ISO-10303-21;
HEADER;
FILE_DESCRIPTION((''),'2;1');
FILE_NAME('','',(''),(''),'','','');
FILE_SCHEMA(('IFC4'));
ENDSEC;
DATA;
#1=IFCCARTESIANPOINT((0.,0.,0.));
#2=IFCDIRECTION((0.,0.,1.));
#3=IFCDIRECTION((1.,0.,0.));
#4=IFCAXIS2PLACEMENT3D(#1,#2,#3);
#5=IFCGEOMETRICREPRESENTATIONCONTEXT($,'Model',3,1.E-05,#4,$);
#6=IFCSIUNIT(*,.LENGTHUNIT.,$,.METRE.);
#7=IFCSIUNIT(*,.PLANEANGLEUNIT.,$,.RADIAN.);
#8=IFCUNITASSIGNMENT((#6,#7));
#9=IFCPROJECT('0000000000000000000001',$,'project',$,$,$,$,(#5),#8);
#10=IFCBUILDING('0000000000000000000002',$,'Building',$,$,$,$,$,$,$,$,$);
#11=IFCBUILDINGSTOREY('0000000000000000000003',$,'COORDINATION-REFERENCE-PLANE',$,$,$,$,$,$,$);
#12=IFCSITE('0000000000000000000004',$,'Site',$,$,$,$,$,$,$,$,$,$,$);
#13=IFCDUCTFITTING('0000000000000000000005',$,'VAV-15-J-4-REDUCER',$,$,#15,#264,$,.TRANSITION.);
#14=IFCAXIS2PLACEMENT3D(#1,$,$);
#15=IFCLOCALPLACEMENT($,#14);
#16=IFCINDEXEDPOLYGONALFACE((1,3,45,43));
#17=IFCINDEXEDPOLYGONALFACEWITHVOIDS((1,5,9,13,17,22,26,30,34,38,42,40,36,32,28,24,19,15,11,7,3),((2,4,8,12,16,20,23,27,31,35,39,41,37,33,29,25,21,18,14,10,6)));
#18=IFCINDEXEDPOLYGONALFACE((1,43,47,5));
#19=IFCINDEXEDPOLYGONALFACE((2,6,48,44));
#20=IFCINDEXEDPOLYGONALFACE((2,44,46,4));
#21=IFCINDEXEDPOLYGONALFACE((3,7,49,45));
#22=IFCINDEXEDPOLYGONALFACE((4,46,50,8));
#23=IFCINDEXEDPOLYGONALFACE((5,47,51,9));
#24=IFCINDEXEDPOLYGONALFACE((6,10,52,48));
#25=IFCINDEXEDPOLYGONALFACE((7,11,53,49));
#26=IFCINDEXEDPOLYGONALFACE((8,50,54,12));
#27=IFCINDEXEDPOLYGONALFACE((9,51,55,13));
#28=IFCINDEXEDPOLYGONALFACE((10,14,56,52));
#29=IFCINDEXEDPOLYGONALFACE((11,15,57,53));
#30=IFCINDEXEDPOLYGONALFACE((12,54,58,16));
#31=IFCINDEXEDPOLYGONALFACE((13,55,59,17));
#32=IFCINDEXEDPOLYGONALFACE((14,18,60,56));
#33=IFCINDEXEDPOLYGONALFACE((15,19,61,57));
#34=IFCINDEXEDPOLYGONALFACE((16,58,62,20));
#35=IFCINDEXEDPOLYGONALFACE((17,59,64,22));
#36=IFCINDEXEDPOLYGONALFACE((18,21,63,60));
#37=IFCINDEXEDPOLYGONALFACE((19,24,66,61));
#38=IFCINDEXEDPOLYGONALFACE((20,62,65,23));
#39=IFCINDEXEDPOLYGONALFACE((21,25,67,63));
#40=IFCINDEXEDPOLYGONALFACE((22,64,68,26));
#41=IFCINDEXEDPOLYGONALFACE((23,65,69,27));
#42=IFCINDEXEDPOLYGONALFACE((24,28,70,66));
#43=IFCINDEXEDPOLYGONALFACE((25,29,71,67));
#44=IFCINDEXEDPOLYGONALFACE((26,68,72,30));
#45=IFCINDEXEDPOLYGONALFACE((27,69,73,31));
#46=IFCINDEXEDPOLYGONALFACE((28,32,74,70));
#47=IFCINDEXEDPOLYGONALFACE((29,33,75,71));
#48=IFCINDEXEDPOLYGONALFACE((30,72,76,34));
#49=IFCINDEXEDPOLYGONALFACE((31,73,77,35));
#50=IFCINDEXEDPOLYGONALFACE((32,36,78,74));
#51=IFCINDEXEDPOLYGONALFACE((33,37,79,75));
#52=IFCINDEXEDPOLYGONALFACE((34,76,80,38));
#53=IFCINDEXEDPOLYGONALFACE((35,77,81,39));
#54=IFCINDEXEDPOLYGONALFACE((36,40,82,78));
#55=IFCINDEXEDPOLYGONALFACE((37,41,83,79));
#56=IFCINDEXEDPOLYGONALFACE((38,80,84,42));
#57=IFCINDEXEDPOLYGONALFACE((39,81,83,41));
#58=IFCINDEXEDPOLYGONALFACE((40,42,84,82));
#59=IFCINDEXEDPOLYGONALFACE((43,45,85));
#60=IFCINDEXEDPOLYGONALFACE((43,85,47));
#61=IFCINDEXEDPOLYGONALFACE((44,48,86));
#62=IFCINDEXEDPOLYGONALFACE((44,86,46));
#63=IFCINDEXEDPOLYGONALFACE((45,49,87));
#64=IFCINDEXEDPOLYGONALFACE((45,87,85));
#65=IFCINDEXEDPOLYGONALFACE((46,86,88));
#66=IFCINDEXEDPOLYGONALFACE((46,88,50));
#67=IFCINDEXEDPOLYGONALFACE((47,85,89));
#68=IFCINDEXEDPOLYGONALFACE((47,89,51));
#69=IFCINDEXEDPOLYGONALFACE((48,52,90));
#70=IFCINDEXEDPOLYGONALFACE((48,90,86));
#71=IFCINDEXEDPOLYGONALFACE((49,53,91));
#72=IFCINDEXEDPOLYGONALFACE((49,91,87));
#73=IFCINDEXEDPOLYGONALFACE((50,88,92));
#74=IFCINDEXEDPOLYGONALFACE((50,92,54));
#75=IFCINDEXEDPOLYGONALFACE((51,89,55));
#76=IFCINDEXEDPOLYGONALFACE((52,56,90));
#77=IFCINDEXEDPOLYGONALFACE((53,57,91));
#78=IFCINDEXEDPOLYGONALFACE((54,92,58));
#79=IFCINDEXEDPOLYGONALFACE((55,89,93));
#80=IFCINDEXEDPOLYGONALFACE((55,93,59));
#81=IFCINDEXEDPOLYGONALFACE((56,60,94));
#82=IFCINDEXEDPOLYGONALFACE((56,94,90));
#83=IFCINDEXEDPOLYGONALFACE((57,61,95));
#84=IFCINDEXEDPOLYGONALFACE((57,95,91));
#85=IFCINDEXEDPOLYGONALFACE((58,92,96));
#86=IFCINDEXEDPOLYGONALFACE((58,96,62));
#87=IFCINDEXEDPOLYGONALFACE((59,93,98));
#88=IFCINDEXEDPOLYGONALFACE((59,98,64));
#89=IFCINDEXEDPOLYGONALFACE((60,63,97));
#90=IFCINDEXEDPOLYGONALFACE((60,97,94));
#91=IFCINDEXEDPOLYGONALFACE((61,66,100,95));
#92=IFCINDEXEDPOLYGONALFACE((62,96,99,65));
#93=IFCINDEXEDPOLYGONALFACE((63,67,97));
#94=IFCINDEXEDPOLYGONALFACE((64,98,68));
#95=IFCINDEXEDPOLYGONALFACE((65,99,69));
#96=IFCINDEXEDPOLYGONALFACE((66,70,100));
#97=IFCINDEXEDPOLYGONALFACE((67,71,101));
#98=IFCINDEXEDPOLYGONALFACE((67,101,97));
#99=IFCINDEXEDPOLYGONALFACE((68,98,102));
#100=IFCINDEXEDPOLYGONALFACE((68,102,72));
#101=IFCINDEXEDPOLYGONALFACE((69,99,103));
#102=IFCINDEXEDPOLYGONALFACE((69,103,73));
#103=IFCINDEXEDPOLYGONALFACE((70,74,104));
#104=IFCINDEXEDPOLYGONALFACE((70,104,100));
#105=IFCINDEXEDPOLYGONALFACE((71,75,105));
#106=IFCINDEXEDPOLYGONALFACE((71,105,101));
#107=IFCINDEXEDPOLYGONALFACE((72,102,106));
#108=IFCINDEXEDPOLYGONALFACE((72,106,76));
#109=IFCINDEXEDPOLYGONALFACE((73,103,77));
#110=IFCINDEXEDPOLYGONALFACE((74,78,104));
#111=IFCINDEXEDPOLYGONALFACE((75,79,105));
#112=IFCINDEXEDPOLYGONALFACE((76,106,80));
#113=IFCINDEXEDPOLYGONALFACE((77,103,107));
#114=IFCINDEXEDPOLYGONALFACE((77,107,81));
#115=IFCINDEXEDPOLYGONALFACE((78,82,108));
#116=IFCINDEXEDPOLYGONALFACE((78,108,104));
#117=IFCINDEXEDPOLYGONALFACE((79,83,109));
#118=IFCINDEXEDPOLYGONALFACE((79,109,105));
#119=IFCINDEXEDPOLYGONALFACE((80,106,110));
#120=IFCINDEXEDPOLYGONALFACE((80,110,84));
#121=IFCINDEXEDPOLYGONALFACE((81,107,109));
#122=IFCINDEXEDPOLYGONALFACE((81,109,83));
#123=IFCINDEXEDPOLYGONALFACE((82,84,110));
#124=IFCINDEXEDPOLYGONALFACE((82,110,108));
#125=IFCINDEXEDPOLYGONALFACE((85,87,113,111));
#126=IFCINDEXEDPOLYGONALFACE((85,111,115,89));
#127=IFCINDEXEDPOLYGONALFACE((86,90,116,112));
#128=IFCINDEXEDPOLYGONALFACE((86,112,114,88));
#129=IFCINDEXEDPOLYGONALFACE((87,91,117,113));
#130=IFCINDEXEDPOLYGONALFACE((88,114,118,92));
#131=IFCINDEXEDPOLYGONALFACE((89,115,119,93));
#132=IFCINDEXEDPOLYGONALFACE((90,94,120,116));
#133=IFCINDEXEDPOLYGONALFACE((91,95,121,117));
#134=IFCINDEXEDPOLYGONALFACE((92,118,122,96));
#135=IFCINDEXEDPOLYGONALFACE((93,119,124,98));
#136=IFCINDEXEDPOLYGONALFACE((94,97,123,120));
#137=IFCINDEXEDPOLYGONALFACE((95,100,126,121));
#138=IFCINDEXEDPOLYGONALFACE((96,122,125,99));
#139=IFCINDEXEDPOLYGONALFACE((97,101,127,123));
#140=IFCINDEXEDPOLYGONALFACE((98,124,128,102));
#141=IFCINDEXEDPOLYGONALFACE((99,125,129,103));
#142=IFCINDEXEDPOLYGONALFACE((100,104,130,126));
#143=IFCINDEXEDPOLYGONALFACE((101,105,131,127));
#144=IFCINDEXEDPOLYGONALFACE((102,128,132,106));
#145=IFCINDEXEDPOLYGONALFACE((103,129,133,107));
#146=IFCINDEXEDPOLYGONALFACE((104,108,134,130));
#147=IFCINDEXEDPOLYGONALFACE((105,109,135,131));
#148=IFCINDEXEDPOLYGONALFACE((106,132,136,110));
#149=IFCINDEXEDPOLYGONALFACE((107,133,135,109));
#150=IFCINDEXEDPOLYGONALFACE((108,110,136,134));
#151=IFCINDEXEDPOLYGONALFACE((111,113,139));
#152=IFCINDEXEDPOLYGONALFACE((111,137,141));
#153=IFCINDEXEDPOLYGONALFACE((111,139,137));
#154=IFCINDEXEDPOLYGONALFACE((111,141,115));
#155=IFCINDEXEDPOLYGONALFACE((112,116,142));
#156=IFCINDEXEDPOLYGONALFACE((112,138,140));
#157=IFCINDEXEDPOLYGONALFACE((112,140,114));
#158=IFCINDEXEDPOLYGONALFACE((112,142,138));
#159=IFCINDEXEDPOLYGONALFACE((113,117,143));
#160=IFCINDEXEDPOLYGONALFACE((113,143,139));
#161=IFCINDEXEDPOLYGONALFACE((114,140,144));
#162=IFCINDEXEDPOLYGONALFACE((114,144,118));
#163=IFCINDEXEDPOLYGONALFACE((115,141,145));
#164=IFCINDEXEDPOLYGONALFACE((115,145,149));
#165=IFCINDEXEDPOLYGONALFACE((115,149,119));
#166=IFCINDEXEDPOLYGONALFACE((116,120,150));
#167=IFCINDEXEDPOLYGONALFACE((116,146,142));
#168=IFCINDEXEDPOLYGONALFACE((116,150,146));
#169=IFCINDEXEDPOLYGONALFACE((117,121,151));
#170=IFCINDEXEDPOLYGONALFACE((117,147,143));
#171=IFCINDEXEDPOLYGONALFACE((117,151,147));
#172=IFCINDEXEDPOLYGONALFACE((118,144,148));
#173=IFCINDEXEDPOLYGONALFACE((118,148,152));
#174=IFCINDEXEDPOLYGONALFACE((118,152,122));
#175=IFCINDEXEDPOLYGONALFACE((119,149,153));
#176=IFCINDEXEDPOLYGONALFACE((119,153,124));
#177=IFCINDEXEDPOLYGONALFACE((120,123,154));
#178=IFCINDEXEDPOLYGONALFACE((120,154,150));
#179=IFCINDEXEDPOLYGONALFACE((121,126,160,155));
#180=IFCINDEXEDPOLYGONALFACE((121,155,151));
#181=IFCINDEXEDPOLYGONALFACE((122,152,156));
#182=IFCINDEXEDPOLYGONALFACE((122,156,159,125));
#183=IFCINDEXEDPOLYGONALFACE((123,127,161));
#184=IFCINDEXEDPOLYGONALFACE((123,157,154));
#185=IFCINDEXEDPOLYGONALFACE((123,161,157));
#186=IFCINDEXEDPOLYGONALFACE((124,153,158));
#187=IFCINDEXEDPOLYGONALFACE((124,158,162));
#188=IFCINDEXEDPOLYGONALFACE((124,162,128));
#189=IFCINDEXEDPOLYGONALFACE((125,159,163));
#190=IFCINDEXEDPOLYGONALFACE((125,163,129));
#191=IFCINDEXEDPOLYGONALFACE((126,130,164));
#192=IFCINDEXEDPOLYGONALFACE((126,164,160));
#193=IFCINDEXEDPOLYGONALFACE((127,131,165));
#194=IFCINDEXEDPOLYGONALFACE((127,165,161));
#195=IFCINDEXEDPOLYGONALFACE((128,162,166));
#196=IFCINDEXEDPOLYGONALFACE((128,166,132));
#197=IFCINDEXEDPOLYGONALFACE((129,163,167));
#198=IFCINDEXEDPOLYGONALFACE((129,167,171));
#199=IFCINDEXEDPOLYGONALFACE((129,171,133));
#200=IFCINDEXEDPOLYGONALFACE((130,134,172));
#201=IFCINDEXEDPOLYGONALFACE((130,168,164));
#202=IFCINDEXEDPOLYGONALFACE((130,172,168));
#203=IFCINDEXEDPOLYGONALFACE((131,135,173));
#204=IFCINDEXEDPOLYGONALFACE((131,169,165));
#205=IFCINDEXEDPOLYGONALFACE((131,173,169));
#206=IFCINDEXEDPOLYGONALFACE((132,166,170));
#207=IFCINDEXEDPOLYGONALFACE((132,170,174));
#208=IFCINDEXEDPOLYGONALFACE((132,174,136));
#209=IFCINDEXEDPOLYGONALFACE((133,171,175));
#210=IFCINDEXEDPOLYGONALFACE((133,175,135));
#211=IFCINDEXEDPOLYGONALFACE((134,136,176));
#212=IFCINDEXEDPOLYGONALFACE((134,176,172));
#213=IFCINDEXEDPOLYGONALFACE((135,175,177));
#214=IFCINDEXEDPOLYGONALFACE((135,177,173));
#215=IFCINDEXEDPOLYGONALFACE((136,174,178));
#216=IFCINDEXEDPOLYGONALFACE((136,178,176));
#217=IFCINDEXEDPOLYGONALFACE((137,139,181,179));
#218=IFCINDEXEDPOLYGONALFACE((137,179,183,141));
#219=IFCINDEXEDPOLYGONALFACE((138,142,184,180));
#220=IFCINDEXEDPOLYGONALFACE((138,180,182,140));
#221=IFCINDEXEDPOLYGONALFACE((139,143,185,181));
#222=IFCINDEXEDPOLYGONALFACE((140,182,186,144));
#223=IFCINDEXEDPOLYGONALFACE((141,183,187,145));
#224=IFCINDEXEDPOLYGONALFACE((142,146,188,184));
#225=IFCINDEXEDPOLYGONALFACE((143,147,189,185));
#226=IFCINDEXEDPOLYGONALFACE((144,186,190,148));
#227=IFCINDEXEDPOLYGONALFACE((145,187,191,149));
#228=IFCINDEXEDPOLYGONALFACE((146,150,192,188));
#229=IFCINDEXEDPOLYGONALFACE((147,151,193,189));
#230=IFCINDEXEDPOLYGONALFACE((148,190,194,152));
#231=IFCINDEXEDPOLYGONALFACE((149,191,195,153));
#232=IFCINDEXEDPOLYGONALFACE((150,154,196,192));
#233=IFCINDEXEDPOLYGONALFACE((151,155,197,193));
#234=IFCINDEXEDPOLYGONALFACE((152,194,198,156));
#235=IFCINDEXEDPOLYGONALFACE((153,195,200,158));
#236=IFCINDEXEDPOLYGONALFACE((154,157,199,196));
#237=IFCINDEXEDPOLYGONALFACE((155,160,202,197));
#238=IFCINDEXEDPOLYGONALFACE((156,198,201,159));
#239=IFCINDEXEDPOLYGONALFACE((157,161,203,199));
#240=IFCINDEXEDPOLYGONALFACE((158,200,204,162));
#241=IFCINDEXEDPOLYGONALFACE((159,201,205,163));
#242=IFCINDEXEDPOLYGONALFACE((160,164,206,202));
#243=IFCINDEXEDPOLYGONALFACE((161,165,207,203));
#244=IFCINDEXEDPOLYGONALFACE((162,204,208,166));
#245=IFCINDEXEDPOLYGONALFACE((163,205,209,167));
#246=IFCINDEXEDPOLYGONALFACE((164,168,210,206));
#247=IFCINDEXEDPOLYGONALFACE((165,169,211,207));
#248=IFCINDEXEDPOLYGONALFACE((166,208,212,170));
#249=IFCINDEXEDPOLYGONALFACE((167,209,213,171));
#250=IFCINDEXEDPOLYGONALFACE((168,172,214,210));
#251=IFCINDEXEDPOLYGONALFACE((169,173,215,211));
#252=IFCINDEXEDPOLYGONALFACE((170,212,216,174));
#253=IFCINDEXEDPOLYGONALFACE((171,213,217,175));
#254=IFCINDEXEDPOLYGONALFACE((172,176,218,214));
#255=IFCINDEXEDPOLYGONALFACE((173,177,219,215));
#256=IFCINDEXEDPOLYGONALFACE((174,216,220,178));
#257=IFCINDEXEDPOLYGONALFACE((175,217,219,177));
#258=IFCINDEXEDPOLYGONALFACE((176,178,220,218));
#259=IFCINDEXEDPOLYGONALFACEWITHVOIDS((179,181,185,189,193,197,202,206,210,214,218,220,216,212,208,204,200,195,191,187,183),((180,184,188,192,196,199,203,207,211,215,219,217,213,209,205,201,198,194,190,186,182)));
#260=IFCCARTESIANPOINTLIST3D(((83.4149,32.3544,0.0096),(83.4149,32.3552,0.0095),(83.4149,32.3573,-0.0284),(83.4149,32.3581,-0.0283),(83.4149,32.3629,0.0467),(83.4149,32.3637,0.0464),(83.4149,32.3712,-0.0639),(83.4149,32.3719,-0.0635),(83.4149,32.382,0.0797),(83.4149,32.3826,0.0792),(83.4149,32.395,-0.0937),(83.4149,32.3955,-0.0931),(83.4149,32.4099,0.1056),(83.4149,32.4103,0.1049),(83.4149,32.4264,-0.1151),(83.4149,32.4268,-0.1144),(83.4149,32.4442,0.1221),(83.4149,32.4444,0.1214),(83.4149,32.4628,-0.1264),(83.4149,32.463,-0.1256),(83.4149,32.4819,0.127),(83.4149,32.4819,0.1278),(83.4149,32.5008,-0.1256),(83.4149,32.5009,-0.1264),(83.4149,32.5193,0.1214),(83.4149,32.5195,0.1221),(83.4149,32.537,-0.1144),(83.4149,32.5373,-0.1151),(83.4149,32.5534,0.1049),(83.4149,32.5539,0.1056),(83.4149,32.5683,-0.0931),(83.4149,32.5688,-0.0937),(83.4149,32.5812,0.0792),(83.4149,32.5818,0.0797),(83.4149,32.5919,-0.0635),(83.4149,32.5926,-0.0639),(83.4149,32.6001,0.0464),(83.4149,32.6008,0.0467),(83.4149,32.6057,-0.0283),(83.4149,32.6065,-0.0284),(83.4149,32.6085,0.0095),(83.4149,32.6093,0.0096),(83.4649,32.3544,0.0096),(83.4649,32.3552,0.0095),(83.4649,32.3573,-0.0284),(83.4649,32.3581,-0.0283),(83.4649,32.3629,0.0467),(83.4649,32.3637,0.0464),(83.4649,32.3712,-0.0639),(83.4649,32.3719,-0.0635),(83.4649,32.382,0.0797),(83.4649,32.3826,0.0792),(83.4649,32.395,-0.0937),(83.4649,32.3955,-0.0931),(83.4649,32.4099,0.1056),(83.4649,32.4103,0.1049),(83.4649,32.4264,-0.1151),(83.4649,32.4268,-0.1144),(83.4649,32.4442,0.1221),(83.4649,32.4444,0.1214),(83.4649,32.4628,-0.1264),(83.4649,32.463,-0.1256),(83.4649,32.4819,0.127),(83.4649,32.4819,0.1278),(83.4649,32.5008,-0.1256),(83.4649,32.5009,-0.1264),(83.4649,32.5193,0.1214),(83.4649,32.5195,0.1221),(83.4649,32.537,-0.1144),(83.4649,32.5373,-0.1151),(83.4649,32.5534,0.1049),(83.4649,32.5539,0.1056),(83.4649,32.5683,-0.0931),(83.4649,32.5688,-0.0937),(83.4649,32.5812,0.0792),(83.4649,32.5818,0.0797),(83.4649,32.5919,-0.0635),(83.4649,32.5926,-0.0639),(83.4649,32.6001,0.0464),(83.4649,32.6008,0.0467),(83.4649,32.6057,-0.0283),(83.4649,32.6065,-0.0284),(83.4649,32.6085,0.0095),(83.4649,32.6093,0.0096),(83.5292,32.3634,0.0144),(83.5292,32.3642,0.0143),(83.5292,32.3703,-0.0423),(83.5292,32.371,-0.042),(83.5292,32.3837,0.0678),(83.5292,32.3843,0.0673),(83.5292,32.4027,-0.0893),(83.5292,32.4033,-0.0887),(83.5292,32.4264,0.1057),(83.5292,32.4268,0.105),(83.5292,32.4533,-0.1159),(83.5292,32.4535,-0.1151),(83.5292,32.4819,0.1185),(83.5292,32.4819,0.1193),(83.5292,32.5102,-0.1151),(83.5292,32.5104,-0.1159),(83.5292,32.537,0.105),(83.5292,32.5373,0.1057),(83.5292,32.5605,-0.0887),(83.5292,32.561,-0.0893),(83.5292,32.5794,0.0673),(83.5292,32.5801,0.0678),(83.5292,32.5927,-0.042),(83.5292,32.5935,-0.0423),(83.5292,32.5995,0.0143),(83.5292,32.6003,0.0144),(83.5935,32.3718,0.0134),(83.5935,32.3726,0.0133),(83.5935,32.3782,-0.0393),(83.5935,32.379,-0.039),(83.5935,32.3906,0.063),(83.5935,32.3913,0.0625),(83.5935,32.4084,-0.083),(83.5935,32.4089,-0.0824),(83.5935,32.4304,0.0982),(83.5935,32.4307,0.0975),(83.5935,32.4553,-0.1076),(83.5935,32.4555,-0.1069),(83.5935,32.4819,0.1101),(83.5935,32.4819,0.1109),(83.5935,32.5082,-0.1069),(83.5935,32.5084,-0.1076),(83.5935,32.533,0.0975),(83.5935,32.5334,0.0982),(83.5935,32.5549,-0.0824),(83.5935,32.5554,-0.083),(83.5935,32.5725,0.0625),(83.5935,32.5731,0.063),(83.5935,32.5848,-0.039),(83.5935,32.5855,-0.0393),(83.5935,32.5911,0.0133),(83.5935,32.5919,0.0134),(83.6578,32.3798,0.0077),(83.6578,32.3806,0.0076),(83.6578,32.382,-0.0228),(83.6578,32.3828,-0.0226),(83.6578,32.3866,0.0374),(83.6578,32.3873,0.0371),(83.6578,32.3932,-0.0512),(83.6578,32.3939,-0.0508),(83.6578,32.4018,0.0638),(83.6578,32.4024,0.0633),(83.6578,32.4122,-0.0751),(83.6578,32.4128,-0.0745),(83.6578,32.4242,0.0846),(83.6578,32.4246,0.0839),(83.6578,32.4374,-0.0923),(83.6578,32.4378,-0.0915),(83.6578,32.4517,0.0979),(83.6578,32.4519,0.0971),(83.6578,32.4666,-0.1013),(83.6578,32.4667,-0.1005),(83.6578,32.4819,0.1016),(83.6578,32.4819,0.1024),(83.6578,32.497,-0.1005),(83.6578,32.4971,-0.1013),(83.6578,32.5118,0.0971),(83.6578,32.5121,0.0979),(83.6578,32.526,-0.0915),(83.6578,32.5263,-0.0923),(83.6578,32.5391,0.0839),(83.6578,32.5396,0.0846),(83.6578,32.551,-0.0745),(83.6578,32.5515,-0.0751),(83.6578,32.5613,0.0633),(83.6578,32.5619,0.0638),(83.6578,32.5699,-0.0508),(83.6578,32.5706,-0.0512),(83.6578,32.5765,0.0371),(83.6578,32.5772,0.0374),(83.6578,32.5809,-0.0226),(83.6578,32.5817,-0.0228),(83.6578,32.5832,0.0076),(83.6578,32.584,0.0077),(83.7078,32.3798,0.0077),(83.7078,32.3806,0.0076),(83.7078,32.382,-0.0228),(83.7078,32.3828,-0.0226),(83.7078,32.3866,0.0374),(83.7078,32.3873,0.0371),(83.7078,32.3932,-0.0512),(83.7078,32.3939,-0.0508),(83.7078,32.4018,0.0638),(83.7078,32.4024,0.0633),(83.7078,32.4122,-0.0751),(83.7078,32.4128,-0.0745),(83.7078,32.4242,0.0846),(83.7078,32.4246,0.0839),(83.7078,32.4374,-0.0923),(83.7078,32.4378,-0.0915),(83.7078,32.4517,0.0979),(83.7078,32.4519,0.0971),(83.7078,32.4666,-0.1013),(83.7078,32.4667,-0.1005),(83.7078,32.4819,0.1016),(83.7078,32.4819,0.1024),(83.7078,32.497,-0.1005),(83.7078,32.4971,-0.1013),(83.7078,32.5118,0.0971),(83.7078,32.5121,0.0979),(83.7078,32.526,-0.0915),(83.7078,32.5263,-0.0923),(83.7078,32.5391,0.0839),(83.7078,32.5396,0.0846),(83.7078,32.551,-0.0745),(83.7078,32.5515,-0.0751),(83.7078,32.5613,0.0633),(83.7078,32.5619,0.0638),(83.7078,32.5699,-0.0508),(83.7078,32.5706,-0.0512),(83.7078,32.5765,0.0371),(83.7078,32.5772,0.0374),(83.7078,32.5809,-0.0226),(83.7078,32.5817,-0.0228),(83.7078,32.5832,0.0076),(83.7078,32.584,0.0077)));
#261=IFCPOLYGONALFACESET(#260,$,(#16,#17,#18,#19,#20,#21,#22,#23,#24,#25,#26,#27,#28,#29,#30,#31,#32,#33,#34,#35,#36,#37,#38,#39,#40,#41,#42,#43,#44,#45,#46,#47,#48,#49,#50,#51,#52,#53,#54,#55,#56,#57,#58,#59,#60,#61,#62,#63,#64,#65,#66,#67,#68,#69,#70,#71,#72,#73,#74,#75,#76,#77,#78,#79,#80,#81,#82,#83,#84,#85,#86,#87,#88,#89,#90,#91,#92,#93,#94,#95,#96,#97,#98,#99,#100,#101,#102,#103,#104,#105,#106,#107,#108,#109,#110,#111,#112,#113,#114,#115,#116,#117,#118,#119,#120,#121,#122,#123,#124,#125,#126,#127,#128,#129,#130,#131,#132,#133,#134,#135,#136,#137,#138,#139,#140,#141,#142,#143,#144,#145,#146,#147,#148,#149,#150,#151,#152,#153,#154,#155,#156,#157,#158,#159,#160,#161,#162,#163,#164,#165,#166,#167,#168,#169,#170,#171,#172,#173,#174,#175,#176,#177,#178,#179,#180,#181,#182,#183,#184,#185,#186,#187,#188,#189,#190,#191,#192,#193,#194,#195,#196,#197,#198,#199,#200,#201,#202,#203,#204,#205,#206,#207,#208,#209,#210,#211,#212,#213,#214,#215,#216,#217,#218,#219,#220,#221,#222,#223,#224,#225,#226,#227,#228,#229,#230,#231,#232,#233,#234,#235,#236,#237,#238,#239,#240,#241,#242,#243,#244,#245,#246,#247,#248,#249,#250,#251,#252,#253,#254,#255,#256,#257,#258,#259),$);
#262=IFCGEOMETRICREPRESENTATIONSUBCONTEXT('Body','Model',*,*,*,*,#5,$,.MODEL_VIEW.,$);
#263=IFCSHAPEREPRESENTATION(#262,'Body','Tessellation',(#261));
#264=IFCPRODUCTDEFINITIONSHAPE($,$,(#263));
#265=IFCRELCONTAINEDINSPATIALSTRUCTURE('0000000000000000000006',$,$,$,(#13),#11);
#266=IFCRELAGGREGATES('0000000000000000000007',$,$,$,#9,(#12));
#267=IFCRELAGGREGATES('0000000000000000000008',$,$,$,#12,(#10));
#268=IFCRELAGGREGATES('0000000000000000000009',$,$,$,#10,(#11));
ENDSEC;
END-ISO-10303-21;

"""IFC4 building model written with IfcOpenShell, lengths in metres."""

from ifc_helpers import new_model, entity, si_unit, frame, origin_with_axes, place, context, subcontext, project, spatial, element, save


model = new_model("IFC4")

# Units and contexts
model_context = context("Model", 3, precision=1e-05, world=origin_with_axes())
body_context_1 = subcontext(model_context, "Body", "Model", "MODEL_VIEW")
ifc_project = project(units=[si_unit("LENGTHUNIT", "METRE"), si_unit("PLANEANGLEUNIT", "RADIAN")], contexts=[model_context])

# Site, building, storey
site = spatial("IfcSite", under=ifc_project, Name="Site")
building = spatial("IfcBuilding", under=site, Name="Building")
storey = spatial("IfcBuildingStorey", under=building, Name="COORDINATION-REFERENCE-PLANE")

# Duct fitting
duct_fitting_1_placement = place(None, frame((83.4149, 32.4819, 0.0), z_axis=(0.0, 1.0, 0.0), x_axis=(0.0, 0.0, 1.0)))
element("IfcDuctFitting", 1, at=duct_fitting_1_placement, inside=storey, Name="VAV-15-J-4-REDUCER", PredefinedType="TRANSITION", context=body_context_1, shape_type="SweptSolid", body=[
    entity("IfcRevolvedAreaSolid", entity("IfcArbitraryClosedProfileDef", "AREA", None, entity("IfcPolyline", [entity("IfcCartesianPoint", [0.1278, 0.0]), entity("IfcCartesianPoint", [0.1278, 0.05]), entity("IfcCartesianPoint", [0.1024, 0.2429]), entity("IfcCartesianPoint", [0.1024, 0.2929]), entity("IfcCartesianPoint", [0.1016, 0.2929]), entity("IfcCartesianPoint", [0.1016, 0.2429]), entity("IfcCartesianPoint", [0.127, 0.05]), entity("IfcCartesianPoint", [0.127, 0.0]), entity("IfcCartesianPoint", [0.1278, 0.0])])), entity("IfcAxis2Placement3D", entity("IfcCartesianPoint", [0.0, 0.0, 0.0])), entity("IfcAxis1Placement", entity("IfcCartesianPoint", [0.0, 0.0, 0.0]), entity("IfcDirection", [0.0, 1.0, 0.0])), 6.283185),
])

save(model, "model.ifc")
